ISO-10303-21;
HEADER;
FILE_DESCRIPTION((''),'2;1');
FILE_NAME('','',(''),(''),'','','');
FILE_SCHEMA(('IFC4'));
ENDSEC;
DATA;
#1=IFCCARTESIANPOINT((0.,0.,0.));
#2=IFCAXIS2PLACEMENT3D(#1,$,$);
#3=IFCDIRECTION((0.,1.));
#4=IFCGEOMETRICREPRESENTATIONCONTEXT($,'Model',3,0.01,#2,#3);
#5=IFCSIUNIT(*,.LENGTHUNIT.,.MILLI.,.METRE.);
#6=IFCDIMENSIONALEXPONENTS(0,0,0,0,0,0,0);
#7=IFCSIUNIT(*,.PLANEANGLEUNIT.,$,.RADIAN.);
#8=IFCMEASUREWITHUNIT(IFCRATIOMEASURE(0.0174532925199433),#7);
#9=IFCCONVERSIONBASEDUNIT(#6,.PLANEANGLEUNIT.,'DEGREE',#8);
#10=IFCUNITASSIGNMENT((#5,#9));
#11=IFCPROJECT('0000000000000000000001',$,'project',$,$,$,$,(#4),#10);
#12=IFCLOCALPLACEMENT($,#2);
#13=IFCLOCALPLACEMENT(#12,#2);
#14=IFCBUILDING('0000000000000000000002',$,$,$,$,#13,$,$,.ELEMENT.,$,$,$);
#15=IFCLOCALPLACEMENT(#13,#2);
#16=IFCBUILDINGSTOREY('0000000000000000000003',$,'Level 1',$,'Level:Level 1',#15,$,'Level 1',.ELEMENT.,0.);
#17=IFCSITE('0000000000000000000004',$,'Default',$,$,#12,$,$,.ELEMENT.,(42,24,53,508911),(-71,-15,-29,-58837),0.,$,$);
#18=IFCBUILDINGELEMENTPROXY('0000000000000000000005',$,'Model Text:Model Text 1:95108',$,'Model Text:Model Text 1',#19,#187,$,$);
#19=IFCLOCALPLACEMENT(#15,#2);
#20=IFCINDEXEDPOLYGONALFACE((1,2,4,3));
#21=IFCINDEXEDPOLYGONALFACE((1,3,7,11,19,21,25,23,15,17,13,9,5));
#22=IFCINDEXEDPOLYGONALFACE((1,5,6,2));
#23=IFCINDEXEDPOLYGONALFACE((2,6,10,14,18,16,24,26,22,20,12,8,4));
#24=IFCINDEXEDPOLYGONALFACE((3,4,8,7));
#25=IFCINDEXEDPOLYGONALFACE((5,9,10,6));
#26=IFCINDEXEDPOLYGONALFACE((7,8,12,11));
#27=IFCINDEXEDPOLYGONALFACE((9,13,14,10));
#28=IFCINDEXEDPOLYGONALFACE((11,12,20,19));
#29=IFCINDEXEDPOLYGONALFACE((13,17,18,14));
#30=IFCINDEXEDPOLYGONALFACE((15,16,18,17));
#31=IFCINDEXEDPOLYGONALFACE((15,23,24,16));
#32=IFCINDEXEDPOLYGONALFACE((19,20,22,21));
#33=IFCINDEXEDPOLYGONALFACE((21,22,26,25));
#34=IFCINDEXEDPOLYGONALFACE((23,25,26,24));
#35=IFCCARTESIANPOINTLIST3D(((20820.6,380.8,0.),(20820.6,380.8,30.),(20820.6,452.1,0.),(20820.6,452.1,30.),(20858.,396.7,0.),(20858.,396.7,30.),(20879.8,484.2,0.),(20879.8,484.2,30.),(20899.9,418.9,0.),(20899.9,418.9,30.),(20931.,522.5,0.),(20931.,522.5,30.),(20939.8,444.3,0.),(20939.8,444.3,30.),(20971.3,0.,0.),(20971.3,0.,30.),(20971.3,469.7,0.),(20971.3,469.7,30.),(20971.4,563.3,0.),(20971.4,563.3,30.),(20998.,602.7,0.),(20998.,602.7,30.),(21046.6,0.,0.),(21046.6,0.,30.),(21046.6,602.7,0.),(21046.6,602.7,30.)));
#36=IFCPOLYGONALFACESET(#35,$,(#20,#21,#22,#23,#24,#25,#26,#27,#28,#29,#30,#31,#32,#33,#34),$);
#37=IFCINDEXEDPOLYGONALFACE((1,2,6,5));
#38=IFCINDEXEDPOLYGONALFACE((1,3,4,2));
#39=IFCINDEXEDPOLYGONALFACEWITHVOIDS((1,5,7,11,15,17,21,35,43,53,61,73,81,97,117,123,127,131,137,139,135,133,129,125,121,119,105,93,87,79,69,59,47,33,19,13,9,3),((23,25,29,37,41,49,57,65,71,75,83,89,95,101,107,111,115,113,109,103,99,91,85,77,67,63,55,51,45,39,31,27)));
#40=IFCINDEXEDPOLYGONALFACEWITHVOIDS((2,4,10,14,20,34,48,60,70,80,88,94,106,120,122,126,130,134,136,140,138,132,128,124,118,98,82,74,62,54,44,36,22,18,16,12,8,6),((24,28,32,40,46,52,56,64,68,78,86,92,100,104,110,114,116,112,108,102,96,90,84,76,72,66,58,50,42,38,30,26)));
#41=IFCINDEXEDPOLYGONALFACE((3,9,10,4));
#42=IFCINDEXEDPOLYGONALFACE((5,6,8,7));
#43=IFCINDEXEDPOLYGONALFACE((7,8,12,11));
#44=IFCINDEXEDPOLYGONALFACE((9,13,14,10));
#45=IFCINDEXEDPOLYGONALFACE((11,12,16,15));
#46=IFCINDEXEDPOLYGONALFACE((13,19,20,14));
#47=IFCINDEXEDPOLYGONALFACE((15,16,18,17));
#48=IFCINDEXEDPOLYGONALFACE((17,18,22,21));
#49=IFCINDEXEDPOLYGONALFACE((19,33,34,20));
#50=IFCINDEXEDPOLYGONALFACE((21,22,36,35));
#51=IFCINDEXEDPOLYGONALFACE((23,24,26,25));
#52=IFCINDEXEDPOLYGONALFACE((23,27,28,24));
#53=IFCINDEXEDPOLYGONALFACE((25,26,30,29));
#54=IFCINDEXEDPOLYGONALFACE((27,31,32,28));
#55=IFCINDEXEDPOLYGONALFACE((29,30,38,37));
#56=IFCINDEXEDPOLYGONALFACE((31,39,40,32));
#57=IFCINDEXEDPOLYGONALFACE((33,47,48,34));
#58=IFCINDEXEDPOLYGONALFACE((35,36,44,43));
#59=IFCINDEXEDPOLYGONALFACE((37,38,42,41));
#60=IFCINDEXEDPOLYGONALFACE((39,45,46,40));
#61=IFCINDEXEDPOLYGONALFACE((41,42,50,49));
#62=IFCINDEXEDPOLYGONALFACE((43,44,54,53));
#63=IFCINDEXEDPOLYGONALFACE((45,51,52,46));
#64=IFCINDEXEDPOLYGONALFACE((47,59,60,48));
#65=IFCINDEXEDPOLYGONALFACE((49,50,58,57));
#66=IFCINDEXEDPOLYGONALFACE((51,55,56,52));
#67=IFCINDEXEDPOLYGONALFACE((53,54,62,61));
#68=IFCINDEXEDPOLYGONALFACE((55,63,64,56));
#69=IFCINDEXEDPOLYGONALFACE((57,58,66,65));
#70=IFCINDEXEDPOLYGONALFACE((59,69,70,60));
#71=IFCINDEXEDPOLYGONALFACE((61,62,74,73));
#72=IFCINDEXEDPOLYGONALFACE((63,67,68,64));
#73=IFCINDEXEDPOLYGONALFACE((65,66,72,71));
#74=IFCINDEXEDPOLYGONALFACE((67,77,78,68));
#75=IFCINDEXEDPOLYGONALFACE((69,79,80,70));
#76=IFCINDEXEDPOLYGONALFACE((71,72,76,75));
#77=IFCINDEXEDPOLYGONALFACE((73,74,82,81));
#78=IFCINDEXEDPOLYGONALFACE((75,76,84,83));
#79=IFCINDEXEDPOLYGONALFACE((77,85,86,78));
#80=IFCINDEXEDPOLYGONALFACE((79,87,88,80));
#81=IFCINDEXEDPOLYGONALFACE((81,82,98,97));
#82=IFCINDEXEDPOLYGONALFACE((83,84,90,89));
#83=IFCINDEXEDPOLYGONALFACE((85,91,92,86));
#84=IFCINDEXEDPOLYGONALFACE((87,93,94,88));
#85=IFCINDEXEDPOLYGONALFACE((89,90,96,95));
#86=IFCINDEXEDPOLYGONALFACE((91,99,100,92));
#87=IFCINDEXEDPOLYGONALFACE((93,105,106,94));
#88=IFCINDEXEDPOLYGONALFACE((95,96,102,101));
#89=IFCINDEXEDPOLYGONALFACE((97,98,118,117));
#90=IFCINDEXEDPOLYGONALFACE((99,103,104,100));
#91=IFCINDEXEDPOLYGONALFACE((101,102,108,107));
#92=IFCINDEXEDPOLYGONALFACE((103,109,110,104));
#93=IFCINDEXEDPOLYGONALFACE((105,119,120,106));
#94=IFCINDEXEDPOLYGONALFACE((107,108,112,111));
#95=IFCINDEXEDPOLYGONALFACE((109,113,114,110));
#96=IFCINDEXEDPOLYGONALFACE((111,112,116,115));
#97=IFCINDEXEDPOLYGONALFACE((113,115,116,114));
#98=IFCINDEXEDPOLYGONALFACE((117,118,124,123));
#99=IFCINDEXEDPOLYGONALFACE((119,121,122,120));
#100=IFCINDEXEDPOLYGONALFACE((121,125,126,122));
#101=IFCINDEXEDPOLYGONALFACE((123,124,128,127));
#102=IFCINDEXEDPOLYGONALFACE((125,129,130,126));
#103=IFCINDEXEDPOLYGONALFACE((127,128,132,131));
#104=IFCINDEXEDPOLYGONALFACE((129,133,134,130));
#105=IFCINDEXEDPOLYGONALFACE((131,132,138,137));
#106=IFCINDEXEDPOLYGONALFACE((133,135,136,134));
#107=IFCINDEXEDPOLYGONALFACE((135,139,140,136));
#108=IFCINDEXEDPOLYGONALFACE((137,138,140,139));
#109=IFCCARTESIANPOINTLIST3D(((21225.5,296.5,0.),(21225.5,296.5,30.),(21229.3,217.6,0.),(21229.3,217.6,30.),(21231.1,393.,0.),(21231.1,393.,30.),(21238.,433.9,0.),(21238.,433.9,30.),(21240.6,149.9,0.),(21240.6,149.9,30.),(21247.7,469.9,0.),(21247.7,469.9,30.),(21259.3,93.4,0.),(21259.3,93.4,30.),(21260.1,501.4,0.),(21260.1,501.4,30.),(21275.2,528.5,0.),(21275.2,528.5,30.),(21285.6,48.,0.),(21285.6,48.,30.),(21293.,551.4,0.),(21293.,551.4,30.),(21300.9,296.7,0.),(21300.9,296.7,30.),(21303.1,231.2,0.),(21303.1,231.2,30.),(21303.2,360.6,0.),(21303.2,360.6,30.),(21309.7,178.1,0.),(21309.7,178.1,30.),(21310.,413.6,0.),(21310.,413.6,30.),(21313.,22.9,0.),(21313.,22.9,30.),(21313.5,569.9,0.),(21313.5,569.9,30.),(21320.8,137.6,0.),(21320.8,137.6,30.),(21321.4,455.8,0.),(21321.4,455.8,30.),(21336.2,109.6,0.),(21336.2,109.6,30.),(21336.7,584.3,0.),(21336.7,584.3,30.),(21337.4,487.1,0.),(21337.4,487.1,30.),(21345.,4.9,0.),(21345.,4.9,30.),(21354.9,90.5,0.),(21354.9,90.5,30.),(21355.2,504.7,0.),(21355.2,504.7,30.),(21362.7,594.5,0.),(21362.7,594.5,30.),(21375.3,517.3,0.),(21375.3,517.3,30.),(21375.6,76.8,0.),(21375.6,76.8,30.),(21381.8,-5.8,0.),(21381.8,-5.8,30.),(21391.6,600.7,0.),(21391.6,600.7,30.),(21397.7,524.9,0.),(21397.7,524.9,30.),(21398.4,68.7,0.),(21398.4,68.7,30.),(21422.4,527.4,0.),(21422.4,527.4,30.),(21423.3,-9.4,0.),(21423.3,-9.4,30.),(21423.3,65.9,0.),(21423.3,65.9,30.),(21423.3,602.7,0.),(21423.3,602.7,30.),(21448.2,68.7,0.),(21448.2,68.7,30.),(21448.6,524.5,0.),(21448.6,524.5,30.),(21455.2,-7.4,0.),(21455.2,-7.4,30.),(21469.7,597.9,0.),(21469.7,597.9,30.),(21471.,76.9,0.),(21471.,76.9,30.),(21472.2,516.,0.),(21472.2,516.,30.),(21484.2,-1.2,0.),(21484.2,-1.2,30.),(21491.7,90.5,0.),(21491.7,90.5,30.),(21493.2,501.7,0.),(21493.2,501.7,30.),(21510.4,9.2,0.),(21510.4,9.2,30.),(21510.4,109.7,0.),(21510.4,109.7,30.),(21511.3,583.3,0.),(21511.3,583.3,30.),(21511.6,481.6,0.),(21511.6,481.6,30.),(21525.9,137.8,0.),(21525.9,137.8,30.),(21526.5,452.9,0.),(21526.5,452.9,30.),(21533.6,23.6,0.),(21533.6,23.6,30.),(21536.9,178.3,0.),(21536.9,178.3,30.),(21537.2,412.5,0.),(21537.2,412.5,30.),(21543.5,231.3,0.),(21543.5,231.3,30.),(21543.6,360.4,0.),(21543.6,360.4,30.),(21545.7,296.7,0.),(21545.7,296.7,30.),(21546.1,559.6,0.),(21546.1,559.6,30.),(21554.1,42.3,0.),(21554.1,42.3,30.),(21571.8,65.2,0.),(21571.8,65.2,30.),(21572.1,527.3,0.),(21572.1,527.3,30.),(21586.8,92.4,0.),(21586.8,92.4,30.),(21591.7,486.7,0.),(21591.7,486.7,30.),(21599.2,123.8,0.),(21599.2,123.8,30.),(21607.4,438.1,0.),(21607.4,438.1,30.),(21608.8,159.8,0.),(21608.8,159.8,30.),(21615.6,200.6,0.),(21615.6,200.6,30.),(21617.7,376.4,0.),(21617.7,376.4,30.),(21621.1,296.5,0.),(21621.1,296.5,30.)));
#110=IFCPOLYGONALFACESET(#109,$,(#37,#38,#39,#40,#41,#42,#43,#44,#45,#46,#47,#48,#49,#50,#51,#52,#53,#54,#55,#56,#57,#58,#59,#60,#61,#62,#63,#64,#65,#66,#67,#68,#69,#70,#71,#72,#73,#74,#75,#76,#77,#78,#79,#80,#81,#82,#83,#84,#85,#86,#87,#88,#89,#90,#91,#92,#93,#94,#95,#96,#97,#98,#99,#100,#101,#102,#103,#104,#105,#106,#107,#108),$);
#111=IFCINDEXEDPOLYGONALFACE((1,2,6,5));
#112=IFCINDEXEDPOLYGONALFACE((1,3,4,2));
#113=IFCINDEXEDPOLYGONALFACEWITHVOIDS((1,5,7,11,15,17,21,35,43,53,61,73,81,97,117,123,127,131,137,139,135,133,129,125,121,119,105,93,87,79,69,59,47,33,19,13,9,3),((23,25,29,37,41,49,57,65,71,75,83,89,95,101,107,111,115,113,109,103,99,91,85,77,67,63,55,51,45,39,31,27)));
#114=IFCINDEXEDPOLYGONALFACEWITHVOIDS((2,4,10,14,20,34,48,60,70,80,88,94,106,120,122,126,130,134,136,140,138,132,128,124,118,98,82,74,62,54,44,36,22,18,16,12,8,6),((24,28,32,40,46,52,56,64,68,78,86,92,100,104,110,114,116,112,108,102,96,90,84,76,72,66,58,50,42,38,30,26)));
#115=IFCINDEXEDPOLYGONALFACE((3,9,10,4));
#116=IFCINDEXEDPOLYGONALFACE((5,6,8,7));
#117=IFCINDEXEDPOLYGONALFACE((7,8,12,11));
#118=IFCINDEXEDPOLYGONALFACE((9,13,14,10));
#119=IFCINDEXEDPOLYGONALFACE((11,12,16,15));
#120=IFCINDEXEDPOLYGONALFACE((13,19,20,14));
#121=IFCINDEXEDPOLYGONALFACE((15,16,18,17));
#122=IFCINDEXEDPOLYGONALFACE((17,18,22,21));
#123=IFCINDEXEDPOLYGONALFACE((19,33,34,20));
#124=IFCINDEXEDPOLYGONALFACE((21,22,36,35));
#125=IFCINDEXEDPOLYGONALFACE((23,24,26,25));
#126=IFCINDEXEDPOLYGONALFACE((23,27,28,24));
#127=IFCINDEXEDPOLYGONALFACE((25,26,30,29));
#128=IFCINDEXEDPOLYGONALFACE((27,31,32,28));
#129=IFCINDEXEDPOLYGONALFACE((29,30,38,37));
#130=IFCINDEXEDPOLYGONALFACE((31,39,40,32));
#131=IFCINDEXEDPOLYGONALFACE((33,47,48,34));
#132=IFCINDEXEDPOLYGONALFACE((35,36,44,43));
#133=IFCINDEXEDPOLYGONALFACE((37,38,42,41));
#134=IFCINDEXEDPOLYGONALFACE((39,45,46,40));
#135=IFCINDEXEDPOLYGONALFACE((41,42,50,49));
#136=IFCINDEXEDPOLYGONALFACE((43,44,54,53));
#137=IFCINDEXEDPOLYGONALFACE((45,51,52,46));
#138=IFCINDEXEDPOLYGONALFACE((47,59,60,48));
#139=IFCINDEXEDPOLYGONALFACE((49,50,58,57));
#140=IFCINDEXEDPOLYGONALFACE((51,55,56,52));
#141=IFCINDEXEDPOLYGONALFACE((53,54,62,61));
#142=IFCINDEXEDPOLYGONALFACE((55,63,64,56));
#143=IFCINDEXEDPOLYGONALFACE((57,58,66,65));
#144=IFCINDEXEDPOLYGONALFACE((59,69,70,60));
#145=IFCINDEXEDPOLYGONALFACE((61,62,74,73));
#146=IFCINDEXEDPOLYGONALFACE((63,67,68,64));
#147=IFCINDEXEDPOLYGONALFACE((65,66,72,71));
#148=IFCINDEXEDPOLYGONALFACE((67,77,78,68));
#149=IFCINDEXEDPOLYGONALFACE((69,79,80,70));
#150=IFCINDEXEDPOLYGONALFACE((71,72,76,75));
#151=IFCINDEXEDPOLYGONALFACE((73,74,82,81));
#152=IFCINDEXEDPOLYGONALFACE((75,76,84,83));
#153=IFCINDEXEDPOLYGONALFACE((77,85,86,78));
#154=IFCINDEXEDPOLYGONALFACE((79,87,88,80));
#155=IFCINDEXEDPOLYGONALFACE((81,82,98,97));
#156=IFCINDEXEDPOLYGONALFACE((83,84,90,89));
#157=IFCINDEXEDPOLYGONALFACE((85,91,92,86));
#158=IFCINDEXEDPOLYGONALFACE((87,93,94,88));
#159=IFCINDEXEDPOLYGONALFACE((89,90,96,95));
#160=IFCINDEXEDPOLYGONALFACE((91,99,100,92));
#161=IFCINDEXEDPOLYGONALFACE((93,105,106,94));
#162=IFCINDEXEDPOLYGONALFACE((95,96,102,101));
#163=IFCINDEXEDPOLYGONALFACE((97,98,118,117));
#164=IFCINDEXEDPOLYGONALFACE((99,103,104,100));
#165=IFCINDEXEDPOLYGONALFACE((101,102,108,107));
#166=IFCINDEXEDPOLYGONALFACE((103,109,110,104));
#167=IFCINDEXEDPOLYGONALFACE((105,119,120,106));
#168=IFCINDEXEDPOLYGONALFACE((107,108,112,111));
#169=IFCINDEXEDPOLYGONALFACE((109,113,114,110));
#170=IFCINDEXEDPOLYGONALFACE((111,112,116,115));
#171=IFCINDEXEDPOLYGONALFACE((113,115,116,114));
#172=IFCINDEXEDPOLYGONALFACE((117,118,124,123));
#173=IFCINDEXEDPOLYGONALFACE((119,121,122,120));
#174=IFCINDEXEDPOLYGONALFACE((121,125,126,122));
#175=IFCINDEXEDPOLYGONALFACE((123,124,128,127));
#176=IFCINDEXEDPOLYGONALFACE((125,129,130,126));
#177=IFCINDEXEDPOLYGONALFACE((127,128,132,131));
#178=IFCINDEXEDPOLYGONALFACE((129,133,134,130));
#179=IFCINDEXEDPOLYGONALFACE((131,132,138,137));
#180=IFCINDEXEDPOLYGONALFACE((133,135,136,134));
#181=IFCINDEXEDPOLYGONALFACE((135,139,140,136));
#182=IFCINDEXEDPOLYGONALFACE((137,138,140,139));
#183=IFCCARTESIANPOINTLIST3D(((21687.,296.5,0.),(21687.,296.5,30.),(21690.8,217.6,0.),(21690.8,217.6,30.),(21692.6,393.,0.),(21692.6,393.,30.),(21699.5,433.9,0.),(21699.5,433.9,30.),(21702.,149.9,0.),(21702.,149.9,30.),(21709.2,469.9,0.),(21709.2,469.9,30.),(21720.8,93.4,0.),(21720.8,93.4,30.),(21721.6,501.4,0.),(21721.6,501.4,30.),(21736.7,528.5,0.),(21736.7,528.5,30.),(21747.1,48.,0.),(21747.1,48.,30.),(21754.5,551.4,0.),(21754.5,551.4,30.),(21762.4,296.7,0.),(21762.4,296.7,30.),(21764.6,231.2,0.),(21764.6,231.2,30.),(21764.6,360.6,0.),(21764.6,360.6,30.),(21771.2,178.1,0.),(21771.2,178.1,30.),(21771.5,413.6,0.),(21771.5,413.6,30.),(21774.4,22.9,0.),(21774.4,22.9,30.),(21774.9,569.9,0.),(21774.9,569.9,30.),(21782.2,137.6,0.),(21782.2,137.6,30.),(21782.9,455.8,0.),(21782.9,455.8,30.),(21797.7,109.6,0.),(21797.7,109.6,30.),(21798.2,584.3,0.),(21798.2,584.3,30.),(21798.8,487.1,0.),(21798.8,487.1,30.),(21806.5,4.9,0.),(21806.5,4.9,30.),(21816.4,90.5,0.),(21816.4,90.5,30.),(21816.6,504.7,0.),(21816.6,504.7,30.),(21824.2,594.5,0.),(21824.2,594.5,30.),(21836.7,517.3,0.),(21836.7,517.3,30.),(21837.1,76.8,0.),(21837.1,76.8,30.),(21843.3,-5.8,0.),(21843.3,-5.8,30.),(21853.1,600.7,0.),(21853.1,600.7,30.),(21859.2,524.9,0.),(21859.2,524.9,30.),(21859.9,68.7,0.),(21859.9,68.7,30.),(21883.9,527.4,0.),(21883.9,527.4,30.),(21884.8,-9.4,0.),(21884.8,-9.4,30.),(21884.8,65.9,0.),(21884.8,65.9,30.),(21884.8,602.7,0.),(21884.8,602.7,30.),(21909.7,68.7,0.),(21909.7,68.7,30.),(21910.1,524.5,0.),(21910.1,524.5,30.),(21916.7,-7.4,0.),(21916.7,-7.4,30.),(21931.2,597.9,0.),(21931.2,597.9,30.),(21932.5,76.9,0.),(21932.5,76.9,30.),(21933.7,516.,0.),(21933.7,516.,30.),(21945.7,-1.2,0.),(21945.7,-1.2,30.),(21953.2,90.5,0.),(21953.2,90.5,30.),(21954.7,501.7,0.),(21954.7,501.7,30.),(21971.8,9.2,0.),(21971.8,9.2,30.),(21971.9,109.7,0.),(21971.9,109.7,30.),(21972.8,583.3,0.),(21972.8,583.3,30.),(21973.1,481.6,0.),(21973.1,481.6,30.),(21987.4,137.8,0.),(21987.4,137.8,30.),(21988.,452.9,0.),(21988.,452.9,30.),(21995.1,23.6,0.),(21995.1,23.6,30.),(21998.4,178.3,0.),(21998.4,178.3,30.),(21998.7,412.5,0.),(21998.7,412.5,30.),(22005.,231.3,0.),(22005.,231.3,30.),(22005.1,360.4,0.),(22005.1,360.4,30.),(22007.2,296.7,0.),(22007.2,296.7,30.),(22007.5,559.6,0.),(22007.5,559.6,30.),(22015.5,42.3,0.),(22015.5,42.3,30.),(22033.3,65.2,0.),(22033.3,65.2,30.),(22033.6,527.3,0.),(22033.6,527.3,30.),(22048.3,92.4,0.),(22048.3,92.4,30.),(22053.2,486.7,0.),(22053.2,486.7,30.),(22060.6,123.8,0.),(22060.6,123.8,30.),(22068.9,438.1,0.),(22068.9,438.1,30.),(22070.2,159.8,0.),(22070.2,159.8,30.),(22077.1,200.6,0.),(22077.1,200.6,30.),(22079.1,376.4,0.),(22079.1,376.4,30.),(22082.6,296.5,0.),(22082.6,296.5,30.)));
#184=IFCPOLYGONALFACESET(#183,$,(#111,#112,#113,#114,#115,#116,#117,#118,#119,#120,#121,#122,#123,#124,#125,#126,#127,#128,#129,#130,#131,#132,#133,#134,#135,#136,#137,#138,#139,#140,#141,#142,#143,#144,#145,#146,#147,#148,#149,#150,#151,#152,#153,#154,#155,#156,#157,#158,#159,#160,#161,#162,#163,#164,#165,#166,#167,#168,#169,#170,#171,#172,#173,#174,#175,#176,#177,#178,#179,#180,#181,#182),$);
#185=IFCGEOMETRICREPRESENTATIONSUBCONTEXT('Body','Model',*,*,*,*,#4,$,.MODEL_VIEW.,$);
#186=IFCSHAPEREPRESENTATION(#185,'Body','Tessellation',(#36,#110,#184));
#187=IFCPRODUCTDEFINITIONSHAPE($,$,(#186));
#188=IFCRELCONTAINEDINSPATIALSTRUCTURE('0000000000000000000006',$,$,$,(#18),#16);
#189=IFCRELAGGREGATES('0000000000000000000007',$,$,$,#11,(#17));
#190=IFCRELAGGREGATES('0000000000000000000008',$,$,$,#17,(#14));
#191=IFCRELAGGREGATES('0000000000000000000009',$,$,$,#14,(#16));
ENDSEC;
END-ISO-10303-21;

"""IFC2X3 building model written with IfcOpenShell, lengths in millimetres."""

from ifc_helpers import new_model, entity, si_unit, converted_unit, direction, frame, origin, place, context, subcontext, project, spatial, polyline, outline, extrude, element, save


model = new_model("IFC2X3")

# Units and contexts
model_context = context("Model", 3, precision=0.01, world=origin(), true_north=direction((0.0, 1.0)))
body_context = subcontext(model_context, "Body", "Model", "MODEL_VIEW")
ifc_project = project(units=[si_unit("LENGTHUNIT", "METRE", prefix="MILLI"), converted_unit("PLANEANGLEUNIT", "DEGREE", entity("IfcRatioMeasure", 0.0174532925199433), si_unit("PLANEANGLEUNIT", "RADIAN"), dimensions=[0, 0, 0, 0, 0, 0, 0])], contexts=[model_context])

# Site, building, storey
site_placement = place(None, origin())
site = spatial("IfcSite", under=ifc_project, at=site_placement, Name="Default", CompositionType="ELEMENT", RefLatitude=(42, 24, 53, 508911), RefLongitude=(-71, -15, -29, -58837), RefElevation=0.0)
building_placement = place(site_placement, origin())
building = spatial("IfcBuilding", under=site, at=building_placement, CompositionType="ELEMENT")
storey_placement = place(building_placement, origin())
storey = spatial("IfcBuildingStorey", under=building, at=storey_placement, Name="Level 1", ObjectType="Level:Level 1", LongName="Level 1", CompositionType="ELEMENT", Elevation=0.0)

# Building element proxy
proxy_1_placement = place(storey_placement, origin())
element("IfcBuildingElementProxy", 1, at=proxy_1_placement, inside=storey, Name="Model Text:Model Text 1:95108", ObjectType="Model Text:Model Text 1", context=body_context, shape_type="SweptSolid", body=[
    extrude(outline(polyline([(-410.6, -111.6), (192.1, -111.6), (192.1, -63.1), (152.7, -36.4), (111.9, 4.0), (73.6, 55.2), (41.4, 114.4), (-29.8, 114.4), (-13.9, 77.0), (8.3, 35.1), (33.7, -4.8), (59.1, -36.3), (-410.6, -36.3), (-410.6, -111.6)])), frame((20935.0, 410.6, 0.0), z_axis=(0.0, 0.0, 1.0), x_axis=(0.0, 1.0, 0.0)), (0.0, 0.0, 1.0), 30.0),
    extrude(outline(polyline([(-10.6, -198.7), (68.3, -198.7), (136.5, -190.7), (193.9, -174.7), (240.5, -150.6), (266.9, -124.4), (286.3, -93.2), (298.8, -57.0), (304.3, -15.7), (303.8, 16.2), (299.0, 45.5), (289.9, 72.1), (276.6, 96.0), (258.9, 117.3), (236.9, 136.2), (210.4, 152.5), (179.6, 166.3), (144.1, 177.6), (103.7, 186.3), (8.2, 196.4), (-71.8, 196.7), (-134.0, 189.4), (-183.3, 176.1), (-224.7, 158.4), (-258.2, 133.9), (-283.5, 100.3), (-300.1, 59.5), (-307.1, 13.4), (-306.6, -18.4), (-301.8, -47.5), (-292.8, -74.0), (-279.6, -97.9), (-262.0, -119.2), (-240.0, -138.1), (-213.6, -154.5), (-182.8, -168.4), (-147.3, -179.8), (-106.7, -188.6), (-10.6, -198.7)]), holes=[polyline([(-7.2, -123.5), (-71.0, -118.2), (-123.6, -108.8), (-165.2, -95.4), (-195.7, -78.0), (-212.4, -59.4), (-224.1, -38.7), (-230.6, -15.9), (-231.9, 8.9), (-227.8, 35.0), (-218.1, 58.1), (-202.8, 78.4), (-182.0, 95.8), (-152.6, 109.4), (-111.7, 118.1), (-59.4, 122.0), (4.4, 121.1), (69.6, 115.8), (122.2, 106.7), (162.2, 93.7), (189.5, 77.0), (207.7, 57.4), (220.4, 36.0), (227.5, 12.8), (229.1, -12.1), (225.2, -36.8), (215.9, -59.2), (201.3, -79.3), (181.4, -97.1), (152.6, -111.2), (111.6, -120.3), (58.3, -124.4), (-7.2, -123.5)])]), frame((21424.6, 295.3, 0.0), z_axis=(0.0, 0.0, 1.0), x_axis=(0.047515, -0.998871, 0.0)), (0.0, 0.0, 1.0), 30.0),
    extrude(outline(polyline([(-10.6, -198.7), (68.3, -198.7), (136.5, -190.7), (193.9, -174.7), (240.5, -150.6), (266.9, -124.4), (286.3, -93.2), (298.8, -57.0), (304.3, -15.7), (303.8, 16.2), (299.0, 45.5), (289.9, 72.1), (276.6, 96.0), (258.9, 117.3), (236.9, 136.2), (210.4, 152.5), (179.6, 166.3), (144.1, 177.6), (103.7, 186.3), (8.2, 196.4), (-71.8, 196.7), (-134.0, 189.4), (-183.3, 176.1), (-224.7, 158.4), (-258.2, 133.9), (-283.5, 100.3), (-300.1, 59.5), (-307.1, 13.4), (-306.6, -18.4), (-301.8, -47.5), (-292.8, -74.0), (-279.6, -97.9), (-262.0, -119.2), (-240.0, -138.1), (-213.6, -154.5), (-182.8, -168.4), (-147.3, -179.8), (-106.7, -188.6), (-10.6, -198.7)]), holes=[polyline([(-7.2, -123.5), (-71.0, -118.2), (-123.6, -108.8), (-165.2, -95.4), (-195.7, -78.0), (-212.4, -59.4), (-224.1, -38.7), (-230.6, -15.9), (-231.9, 8.9), (-227.8, 35.0), (-218.1, 58.1), (-202.8, 78.4), (-182.0, 95.8), (-152.6, 109.4), (-111.7, 118.1), (-59.4, 122.0), (4.4, 121.1), (69.6, 115.8), (122.2, 106.7), (162.2, 93.7), (189.5, 77.0), (207.7, 57.4), (220.4, 36.0), (227.5, 12.8), (229.1, -12.1), (225.2, -36.8), (215.9, -59.2), (201.3, -79.3), (181.4, -97.1), (152.6, -111.2), (111.6, -120.3), (58.3, -124.4), (-7.2, -123.5)])]), frame((21886.0, 295.3, 0.0), z_axis=(0.0, 0.0, 1.0), x_axis=(0.047515, -0.998871, 0.0)), (0.0, 0.0, 1.0), 30.0),
])

save(model, "model.ifc")
